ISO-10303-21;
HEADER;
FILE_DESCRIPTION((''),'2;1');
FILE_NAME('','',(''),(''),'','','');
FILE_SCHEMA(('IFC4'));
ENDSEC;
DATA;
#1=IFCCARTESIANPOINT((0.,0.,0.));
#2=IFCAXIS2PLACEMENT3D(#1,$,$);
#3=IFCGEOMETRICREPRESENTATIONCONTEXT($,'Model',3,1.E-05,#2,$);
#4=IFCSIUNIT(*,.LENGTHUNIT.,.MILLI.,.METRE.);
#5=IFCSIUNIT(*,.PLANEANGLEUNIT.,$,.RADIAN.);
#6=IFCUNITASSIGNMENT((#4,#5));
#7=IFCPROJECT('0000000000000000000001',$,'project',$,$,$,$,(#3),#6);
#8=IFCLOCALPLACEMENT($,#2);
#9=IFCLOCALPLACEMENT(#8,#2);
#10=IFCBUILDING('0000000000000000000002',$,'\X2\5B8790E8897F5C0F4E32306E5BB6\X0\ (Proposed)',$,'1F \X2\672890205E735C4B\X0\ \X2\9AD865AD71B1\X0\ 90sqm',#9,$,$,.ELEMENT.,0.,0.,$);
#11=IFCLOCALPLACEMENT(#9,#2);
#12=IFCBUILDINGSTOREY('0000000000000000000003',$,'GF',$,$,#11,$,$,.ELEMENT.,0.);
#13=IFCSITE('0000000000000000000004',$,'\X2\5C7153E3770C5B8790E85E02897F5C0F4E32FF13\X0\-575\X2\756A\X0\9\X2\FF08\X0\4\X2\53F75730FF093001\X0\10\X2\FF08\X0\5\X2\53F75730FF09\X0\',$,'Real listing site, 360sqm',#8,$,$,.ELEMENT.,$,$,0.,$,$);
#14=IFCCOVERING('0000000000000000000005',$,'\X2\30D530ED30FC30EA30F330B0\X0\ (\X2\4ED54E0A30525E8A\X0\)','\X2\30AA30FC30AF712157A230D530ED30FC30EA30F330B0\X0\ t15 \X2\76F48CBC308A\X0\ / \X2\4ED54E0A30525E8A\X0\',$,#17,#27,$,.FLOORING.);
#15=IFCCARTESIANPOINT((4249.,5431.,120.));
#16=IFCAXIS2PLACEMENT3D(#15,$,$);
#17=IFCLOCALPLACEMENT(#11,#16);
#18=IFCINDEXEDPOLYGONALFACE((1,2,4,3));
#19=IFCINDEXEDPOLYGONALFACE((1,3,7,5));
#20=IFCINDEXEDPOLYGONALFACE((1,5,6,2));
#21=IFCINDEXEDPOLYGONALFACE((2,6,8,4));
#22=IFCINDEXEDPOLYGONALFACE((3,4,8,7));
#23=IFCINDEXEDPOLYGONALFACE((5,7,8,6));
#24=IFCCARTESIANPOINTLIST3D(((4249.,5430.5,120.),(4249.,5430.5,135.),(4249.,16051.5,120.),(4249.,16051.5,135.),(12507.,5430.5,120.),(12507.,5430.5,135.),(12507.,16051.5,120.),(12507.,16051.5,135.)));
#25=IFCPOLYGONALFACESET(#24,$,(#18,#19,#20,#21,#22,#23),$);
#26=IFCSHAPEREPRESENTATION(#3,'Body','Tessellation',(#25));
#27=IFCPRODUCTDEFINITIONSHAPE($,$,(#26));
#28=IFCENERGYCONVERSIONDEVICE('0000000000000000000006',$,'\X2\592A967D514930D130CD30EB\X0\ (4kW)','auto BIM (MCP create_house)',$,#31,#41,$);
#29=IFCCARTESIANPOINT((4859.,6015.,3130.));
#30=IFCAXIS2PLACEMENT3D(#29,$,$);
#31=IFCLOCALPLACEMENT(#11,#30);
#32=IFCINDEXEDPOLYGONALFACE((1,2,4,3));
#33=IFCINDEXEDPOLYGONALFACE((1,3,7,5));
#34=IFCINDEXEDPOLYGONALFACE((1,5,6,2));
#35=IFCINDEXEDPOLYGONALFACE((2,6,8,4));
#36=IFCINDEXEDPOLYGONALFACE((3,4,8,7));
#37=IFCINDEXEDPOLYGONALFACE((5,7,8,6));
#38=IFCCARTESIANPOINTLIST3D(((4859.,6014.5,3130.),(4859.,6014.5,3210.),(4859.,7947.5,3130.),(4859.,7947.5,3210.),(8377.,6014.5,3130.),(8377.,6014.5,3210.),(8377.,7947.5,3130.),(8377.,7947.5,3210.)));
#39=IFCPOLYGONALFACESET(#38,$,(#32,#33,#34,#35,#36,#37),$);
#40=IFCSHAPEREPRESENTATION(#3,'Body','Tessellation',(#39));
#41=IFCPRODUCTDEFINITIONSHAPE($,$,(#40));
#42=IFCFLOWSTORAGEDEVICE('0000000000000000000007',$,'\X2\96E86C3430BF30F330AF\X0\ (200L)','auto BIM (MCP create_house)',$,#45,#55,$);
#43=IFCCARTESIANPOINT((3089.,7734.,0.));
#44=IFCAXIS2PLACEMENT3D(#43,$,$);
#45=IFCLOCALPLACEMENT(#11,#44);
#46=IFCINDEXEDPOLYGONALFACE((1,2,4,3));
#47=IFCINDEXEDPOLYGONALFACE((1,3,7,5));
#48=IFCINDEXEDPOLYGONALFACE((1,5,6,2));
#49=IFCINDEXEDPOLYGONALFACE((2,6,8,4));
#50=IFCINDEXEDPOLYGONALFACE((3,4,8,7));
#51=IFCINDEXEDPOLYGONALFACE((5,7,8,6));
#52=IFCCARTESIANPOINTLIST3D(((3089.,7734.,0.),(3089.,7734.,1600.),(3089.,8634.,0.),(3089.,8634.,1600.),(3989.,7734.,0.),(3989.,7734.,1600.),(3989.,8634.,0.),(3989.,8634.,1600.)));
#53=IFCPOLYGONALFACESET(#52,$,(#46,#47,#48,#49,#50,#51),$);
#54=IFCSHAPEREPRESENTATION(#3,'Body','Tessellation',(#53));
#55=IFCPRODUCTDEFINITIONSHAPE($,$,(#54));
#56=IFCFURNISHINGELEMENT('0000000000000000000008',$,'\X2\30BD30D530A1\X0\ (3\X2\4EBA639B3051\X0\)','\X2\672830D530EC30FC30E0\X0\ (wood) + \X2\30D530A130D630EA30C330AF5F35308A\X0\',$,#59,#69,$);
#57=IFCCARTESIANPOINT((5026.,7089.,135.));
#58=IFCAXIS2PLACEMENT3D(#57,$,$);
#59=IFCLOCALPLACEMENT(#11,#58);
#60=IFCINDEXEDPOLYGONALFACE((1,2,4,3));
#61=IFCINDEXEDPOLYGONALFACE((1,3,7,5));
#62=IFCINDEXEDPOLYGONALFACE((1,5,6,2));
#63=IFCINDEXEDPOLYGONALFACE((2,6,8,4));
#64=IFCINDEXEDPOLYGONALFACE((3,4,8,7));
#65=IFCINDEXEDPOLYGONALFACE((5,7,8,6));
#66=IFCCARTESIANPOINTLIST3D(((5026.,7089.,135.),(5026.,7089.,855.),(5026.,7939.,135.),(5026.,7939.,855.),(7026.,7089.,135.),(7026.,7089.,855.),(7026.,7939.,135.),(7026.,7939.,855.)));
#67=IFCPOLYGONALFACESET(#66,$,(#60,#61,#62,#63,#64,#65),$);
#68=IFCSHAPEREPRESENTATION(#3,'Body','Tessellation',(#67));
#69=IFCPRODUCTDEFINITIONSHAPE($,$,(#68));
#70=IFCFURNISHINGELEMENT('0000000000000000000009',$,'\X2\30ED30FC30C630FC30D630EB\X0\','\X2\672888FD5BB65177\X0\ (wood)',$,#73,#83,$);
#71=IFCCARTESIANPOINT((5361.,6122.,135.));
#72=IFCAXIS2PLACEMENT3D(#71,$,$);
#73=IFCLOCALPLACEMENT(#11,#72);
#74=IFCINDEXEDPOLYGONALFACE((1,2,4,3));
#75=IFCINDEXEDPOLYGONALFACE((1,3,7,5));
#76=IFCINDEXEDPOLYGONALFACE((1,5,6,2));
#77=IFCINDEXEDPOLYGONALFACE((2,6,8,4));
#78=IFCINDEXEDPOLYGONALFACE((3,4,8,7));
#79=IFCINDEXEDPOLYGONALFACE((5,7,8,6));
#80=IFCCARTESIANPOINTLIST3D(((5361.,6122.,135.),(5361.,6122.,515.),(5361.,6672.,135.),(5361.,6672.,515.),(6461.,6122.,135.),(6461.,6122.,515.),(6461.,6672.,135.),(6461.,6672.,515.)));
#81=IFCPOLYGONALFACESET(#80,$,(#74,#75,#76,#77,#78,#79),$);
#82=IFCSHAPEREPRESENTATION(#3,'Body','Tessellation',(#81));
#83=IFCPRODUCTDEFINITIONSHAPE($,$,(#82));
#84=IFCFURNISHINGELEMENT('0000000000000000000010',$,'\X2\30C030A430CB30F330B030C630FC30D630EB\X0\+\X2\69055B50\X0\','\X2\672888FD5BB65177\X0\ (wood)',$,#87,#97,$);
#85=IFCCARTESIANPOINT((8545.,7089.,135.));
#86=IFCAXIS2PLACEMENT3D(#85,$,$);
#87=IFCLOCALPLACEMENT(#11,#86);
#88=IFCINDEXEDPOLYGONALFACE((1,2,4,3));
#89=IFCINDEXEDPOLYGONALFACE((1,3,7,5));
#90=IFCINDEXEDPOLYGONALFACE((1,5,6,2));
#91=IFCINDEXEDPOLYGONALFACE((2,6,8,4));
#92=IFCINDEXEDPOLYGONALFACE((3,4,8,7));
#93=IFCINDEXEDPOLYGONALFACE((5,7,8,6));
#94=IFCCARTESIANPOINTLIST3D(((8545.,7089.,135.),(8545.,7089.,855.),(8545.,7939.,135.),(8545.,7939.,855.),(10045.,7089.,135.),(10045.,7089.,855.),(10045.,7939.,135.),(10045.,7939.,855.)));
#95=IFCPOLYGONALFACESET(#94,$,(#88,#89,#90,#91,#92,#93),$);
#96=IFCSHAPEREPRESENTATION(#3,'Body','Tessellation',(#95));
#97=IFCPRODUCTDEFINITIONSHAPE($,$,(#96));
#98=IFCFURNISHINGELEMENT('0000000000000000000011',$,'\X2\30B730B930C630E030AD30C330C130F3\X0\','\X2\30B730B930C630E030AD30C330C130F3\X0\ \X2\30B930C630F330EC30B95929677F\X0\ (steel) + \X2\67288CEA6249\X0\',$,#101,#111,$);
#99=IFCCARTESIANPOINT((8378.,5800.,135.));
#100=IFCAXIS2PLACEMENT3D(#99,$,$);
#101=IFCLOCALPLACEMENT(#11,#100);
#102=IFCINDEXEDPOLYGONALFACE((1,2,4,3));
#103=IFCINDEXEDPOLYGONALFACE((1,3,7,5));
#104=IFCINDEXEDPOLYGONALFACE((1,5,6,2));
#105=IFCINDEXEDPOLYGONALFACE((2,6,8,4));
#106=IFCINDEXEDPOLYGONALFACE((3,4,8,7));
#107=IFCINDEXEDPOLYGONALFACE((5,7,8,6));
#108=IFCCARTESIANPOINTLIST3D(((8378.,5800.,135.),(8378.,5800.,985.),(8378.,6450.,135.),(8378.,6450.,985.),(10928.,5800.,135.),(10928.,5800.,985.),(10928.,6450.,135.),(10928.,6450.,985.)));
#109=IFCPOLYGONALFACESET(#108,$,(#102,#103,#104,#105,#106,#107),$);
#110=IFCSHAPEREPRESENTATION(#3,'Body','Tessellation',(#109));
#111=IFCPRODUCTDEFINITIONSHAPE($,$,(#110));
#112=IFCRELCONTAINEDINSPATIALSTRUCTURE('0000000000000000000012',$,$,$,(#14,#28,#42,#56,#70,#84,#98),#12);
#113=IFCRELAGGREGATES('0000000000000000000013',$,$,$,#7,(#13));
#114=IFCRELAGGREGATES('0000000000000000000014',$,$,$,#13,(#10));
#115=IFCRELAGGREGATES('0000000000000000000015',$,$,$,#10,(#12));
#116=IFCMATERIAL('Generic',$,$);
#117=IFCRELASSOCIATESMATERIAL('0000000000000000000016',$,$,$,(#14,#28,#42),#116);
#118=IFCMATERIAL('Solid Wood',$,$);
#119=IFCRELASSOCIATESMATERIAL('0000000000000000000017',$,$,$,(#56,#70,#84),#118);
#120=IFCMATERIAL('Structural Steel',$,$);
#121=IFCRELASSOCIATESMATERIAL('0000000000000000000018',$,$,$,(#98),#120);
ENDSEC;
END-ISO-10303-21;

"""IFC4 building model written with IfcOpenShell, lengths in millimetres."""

from ifc_helpers import new_model, si_unit, frame, frame_2d, origin, place, context, project, spatial, rectangle, extrude, material, element, save


model = new_model("IFC4")

# Units and contexts
model_context = context("Model", 3, precision=1e-05, world=origin())
ifc_project = project(units=[si_unit("LENGTHUNIT", "METRE", prefix="MILLI"), si_unit("PLANEANGLEUNIT", "RADIAN")], contexts=[model_context])

# Site, building, storey
site_placement = place(None, origin())
site = spatial("IfcSite", under=ifc_project, at=site_placement, Name="山口県宇部市西小串３-575番9（4号地）、10（5号地）", ObjectType="Real listing site, 360sqm", CompositionType="ELEMENT", RefElevation=0.0)
building_placement = place(site_placement, origin())
building = spatial("IfcBuilding", under=site, at=building_placement, Name="宇部西小串の家 (Proposed)", ObjectType="1F 木造平屋 高断熱 90sqm", CompositionType="ELEMENT", ElevationOfRefHeight=0.0, ElevationOfTerrain=0.0)
storey_placement = place(building_placement, origin())
storey = spatial("IfcBuildingStorey", under=building, at=storey_placement, Name="GF", CompositionType="ELEMENT", Elevation=0.0)

# Shared definitions
ifc_material_1 = material(Name="Solid Wood")

# Shared definitions
ifc_material_2 = material(Name="Structural Steel")

# Covering
ifc_material_3 = material(Name="Generic")
covering_placement = place(storey_placement, frame((4249.0, 5431.0, 120.0)))
element("IfcCovering", 1, at=covering_placement, inside=storey, material=ifc_material_3, Name="フローリング (仕上げ床)", Description="オーク無垢フローリング t15 直貼り / 仕上げ床", PredefinedType="FLOORING", context=model_context, shape_type="SweptSolid", body=[
    extrude(rectangle(XDim=8258.0, YDim=10621.0, at=frame_2d((4129.0, 5310.0))), frame((4249.0, 5431.0, 120.0)), (0.0, 0.0, 1.0), 15.0),
])

# Energy conversion device
energy_conversion_device_placement = place(storey_placement, frame((4859.0, 6015.0, 3130.0)))
element("IfcEnergyConversionDevice", 2, at=energy_conversion_device_placement, inside=storey, material=ifc_material_3, Name="太陽光パネル (4kW)", Description="auto BIM (MCP create_house)", context=model_context, shape_type="SweptSolid", body=[
    extrude(rectangle(XDim=3518.0, YDim=1933.0, at=frame_2d((1759.0, 966.0))), frame((4859.0, 6015.0, 3130.0)), (0.0, 0.0, 1.0), 80.0),
])

# Flow storage device
flow_storage_device_placement = place(storey_placement, frame((3089.0, 7734.0, 0.0)))
element("IfcFlowStorageDevice", 3, at=flow_storage_device_placement, inside=storey, material=ifc_material_3, Name="雨水タンク (200L)", Description="auto BIM (MCP create_house)", context=model_context, shape_type="SweptSolid", body=[
    extrude(rectangle(XDim=900.0, YDim=900.0, at=frame_2d((450.0, 450.0))), frame((3089.0, 7734.0, 0.0)), (0.0, 0.0, 1.0), 1600.0),
])

# Furnishing elements
furnishing_1_placement = place(storey_placement, frame((5026.0, 7089.0, 135.0)))
element("IfcFurnishingElement", 4, at=furnishing_1_placement, inside=storey, material=ifc_material_1, Name="ソファ (3人掛け)", Description="木フレーム (wood) + ファブリック張り", context=model_context, shape_type="SweptSolid", body=[
    extrude(rectangle(XDim=2000.0, YDim=850.0, at=frame_2d((1000.0, 425.0))), frame((5026.0, 7089.0, 135.0)), (0.0, 0.0, 1.0), 720.0),
])
furnishing_2_placement = place(storey_placement, frame((5361.0, 6122.0, 135.0)))
element("IfcFurnishingElement", 5, at=furnishing_2_placement, inside=storey, material=ifc_material_1, Name="ローテーブル", Description="木製家具 (wood)", context=model_context, shape_type="SweptSolid", body=[
    extrude(rectangle(XDim=1100.0, YDim=550.0, at=frame_2d((550.0, 275.0))), frame((5361.0, 6122.0, 135.0)), (0.0, 0.0, 1.0), 380.0),
])
furnishing_3_placement = place(storey_placement, frame((8545.0, 7089.0, 135.0)))
element("IfcFurnishingElement", 6, at=furnishing_3_placement, inside=storey, material=ifc_material_1, Name="ダイニングテーブル+椅子", Description="木製家具 (wood)", context=model_context, shape_type="SweptSolid", body=[
    extrude(rectangle(XDim=1500.0, YDim=850.0, at=frame_2d((750.0, 425.0))), frame((8545.0, 7089.0, 135.0)), (0.0, 0.0, 1.0), 720.0),
])
furnishing_4_placement = place(storey_placement, frame((8378.0, 5800.0, 135.0)))
element("IfcFurnishingElement", 7, at=furnishing_4_placement, inside=storey, material=ifc_material_2, Name="システムキッチン", Description="システムキッチン ステンレス天板 (steel) + 木質扉", context=model_context, shape_type="SweptSolid", body=[
    extrude(rectangle(XDim=2550.0, YDim=650.0, at=frame_2d((1275.0, 325.0))), frame((8378.0, 5800.0, 135.0)), (0.0, 0.0, 1.0), 850.0),
])

save(model, "model.ifc")
